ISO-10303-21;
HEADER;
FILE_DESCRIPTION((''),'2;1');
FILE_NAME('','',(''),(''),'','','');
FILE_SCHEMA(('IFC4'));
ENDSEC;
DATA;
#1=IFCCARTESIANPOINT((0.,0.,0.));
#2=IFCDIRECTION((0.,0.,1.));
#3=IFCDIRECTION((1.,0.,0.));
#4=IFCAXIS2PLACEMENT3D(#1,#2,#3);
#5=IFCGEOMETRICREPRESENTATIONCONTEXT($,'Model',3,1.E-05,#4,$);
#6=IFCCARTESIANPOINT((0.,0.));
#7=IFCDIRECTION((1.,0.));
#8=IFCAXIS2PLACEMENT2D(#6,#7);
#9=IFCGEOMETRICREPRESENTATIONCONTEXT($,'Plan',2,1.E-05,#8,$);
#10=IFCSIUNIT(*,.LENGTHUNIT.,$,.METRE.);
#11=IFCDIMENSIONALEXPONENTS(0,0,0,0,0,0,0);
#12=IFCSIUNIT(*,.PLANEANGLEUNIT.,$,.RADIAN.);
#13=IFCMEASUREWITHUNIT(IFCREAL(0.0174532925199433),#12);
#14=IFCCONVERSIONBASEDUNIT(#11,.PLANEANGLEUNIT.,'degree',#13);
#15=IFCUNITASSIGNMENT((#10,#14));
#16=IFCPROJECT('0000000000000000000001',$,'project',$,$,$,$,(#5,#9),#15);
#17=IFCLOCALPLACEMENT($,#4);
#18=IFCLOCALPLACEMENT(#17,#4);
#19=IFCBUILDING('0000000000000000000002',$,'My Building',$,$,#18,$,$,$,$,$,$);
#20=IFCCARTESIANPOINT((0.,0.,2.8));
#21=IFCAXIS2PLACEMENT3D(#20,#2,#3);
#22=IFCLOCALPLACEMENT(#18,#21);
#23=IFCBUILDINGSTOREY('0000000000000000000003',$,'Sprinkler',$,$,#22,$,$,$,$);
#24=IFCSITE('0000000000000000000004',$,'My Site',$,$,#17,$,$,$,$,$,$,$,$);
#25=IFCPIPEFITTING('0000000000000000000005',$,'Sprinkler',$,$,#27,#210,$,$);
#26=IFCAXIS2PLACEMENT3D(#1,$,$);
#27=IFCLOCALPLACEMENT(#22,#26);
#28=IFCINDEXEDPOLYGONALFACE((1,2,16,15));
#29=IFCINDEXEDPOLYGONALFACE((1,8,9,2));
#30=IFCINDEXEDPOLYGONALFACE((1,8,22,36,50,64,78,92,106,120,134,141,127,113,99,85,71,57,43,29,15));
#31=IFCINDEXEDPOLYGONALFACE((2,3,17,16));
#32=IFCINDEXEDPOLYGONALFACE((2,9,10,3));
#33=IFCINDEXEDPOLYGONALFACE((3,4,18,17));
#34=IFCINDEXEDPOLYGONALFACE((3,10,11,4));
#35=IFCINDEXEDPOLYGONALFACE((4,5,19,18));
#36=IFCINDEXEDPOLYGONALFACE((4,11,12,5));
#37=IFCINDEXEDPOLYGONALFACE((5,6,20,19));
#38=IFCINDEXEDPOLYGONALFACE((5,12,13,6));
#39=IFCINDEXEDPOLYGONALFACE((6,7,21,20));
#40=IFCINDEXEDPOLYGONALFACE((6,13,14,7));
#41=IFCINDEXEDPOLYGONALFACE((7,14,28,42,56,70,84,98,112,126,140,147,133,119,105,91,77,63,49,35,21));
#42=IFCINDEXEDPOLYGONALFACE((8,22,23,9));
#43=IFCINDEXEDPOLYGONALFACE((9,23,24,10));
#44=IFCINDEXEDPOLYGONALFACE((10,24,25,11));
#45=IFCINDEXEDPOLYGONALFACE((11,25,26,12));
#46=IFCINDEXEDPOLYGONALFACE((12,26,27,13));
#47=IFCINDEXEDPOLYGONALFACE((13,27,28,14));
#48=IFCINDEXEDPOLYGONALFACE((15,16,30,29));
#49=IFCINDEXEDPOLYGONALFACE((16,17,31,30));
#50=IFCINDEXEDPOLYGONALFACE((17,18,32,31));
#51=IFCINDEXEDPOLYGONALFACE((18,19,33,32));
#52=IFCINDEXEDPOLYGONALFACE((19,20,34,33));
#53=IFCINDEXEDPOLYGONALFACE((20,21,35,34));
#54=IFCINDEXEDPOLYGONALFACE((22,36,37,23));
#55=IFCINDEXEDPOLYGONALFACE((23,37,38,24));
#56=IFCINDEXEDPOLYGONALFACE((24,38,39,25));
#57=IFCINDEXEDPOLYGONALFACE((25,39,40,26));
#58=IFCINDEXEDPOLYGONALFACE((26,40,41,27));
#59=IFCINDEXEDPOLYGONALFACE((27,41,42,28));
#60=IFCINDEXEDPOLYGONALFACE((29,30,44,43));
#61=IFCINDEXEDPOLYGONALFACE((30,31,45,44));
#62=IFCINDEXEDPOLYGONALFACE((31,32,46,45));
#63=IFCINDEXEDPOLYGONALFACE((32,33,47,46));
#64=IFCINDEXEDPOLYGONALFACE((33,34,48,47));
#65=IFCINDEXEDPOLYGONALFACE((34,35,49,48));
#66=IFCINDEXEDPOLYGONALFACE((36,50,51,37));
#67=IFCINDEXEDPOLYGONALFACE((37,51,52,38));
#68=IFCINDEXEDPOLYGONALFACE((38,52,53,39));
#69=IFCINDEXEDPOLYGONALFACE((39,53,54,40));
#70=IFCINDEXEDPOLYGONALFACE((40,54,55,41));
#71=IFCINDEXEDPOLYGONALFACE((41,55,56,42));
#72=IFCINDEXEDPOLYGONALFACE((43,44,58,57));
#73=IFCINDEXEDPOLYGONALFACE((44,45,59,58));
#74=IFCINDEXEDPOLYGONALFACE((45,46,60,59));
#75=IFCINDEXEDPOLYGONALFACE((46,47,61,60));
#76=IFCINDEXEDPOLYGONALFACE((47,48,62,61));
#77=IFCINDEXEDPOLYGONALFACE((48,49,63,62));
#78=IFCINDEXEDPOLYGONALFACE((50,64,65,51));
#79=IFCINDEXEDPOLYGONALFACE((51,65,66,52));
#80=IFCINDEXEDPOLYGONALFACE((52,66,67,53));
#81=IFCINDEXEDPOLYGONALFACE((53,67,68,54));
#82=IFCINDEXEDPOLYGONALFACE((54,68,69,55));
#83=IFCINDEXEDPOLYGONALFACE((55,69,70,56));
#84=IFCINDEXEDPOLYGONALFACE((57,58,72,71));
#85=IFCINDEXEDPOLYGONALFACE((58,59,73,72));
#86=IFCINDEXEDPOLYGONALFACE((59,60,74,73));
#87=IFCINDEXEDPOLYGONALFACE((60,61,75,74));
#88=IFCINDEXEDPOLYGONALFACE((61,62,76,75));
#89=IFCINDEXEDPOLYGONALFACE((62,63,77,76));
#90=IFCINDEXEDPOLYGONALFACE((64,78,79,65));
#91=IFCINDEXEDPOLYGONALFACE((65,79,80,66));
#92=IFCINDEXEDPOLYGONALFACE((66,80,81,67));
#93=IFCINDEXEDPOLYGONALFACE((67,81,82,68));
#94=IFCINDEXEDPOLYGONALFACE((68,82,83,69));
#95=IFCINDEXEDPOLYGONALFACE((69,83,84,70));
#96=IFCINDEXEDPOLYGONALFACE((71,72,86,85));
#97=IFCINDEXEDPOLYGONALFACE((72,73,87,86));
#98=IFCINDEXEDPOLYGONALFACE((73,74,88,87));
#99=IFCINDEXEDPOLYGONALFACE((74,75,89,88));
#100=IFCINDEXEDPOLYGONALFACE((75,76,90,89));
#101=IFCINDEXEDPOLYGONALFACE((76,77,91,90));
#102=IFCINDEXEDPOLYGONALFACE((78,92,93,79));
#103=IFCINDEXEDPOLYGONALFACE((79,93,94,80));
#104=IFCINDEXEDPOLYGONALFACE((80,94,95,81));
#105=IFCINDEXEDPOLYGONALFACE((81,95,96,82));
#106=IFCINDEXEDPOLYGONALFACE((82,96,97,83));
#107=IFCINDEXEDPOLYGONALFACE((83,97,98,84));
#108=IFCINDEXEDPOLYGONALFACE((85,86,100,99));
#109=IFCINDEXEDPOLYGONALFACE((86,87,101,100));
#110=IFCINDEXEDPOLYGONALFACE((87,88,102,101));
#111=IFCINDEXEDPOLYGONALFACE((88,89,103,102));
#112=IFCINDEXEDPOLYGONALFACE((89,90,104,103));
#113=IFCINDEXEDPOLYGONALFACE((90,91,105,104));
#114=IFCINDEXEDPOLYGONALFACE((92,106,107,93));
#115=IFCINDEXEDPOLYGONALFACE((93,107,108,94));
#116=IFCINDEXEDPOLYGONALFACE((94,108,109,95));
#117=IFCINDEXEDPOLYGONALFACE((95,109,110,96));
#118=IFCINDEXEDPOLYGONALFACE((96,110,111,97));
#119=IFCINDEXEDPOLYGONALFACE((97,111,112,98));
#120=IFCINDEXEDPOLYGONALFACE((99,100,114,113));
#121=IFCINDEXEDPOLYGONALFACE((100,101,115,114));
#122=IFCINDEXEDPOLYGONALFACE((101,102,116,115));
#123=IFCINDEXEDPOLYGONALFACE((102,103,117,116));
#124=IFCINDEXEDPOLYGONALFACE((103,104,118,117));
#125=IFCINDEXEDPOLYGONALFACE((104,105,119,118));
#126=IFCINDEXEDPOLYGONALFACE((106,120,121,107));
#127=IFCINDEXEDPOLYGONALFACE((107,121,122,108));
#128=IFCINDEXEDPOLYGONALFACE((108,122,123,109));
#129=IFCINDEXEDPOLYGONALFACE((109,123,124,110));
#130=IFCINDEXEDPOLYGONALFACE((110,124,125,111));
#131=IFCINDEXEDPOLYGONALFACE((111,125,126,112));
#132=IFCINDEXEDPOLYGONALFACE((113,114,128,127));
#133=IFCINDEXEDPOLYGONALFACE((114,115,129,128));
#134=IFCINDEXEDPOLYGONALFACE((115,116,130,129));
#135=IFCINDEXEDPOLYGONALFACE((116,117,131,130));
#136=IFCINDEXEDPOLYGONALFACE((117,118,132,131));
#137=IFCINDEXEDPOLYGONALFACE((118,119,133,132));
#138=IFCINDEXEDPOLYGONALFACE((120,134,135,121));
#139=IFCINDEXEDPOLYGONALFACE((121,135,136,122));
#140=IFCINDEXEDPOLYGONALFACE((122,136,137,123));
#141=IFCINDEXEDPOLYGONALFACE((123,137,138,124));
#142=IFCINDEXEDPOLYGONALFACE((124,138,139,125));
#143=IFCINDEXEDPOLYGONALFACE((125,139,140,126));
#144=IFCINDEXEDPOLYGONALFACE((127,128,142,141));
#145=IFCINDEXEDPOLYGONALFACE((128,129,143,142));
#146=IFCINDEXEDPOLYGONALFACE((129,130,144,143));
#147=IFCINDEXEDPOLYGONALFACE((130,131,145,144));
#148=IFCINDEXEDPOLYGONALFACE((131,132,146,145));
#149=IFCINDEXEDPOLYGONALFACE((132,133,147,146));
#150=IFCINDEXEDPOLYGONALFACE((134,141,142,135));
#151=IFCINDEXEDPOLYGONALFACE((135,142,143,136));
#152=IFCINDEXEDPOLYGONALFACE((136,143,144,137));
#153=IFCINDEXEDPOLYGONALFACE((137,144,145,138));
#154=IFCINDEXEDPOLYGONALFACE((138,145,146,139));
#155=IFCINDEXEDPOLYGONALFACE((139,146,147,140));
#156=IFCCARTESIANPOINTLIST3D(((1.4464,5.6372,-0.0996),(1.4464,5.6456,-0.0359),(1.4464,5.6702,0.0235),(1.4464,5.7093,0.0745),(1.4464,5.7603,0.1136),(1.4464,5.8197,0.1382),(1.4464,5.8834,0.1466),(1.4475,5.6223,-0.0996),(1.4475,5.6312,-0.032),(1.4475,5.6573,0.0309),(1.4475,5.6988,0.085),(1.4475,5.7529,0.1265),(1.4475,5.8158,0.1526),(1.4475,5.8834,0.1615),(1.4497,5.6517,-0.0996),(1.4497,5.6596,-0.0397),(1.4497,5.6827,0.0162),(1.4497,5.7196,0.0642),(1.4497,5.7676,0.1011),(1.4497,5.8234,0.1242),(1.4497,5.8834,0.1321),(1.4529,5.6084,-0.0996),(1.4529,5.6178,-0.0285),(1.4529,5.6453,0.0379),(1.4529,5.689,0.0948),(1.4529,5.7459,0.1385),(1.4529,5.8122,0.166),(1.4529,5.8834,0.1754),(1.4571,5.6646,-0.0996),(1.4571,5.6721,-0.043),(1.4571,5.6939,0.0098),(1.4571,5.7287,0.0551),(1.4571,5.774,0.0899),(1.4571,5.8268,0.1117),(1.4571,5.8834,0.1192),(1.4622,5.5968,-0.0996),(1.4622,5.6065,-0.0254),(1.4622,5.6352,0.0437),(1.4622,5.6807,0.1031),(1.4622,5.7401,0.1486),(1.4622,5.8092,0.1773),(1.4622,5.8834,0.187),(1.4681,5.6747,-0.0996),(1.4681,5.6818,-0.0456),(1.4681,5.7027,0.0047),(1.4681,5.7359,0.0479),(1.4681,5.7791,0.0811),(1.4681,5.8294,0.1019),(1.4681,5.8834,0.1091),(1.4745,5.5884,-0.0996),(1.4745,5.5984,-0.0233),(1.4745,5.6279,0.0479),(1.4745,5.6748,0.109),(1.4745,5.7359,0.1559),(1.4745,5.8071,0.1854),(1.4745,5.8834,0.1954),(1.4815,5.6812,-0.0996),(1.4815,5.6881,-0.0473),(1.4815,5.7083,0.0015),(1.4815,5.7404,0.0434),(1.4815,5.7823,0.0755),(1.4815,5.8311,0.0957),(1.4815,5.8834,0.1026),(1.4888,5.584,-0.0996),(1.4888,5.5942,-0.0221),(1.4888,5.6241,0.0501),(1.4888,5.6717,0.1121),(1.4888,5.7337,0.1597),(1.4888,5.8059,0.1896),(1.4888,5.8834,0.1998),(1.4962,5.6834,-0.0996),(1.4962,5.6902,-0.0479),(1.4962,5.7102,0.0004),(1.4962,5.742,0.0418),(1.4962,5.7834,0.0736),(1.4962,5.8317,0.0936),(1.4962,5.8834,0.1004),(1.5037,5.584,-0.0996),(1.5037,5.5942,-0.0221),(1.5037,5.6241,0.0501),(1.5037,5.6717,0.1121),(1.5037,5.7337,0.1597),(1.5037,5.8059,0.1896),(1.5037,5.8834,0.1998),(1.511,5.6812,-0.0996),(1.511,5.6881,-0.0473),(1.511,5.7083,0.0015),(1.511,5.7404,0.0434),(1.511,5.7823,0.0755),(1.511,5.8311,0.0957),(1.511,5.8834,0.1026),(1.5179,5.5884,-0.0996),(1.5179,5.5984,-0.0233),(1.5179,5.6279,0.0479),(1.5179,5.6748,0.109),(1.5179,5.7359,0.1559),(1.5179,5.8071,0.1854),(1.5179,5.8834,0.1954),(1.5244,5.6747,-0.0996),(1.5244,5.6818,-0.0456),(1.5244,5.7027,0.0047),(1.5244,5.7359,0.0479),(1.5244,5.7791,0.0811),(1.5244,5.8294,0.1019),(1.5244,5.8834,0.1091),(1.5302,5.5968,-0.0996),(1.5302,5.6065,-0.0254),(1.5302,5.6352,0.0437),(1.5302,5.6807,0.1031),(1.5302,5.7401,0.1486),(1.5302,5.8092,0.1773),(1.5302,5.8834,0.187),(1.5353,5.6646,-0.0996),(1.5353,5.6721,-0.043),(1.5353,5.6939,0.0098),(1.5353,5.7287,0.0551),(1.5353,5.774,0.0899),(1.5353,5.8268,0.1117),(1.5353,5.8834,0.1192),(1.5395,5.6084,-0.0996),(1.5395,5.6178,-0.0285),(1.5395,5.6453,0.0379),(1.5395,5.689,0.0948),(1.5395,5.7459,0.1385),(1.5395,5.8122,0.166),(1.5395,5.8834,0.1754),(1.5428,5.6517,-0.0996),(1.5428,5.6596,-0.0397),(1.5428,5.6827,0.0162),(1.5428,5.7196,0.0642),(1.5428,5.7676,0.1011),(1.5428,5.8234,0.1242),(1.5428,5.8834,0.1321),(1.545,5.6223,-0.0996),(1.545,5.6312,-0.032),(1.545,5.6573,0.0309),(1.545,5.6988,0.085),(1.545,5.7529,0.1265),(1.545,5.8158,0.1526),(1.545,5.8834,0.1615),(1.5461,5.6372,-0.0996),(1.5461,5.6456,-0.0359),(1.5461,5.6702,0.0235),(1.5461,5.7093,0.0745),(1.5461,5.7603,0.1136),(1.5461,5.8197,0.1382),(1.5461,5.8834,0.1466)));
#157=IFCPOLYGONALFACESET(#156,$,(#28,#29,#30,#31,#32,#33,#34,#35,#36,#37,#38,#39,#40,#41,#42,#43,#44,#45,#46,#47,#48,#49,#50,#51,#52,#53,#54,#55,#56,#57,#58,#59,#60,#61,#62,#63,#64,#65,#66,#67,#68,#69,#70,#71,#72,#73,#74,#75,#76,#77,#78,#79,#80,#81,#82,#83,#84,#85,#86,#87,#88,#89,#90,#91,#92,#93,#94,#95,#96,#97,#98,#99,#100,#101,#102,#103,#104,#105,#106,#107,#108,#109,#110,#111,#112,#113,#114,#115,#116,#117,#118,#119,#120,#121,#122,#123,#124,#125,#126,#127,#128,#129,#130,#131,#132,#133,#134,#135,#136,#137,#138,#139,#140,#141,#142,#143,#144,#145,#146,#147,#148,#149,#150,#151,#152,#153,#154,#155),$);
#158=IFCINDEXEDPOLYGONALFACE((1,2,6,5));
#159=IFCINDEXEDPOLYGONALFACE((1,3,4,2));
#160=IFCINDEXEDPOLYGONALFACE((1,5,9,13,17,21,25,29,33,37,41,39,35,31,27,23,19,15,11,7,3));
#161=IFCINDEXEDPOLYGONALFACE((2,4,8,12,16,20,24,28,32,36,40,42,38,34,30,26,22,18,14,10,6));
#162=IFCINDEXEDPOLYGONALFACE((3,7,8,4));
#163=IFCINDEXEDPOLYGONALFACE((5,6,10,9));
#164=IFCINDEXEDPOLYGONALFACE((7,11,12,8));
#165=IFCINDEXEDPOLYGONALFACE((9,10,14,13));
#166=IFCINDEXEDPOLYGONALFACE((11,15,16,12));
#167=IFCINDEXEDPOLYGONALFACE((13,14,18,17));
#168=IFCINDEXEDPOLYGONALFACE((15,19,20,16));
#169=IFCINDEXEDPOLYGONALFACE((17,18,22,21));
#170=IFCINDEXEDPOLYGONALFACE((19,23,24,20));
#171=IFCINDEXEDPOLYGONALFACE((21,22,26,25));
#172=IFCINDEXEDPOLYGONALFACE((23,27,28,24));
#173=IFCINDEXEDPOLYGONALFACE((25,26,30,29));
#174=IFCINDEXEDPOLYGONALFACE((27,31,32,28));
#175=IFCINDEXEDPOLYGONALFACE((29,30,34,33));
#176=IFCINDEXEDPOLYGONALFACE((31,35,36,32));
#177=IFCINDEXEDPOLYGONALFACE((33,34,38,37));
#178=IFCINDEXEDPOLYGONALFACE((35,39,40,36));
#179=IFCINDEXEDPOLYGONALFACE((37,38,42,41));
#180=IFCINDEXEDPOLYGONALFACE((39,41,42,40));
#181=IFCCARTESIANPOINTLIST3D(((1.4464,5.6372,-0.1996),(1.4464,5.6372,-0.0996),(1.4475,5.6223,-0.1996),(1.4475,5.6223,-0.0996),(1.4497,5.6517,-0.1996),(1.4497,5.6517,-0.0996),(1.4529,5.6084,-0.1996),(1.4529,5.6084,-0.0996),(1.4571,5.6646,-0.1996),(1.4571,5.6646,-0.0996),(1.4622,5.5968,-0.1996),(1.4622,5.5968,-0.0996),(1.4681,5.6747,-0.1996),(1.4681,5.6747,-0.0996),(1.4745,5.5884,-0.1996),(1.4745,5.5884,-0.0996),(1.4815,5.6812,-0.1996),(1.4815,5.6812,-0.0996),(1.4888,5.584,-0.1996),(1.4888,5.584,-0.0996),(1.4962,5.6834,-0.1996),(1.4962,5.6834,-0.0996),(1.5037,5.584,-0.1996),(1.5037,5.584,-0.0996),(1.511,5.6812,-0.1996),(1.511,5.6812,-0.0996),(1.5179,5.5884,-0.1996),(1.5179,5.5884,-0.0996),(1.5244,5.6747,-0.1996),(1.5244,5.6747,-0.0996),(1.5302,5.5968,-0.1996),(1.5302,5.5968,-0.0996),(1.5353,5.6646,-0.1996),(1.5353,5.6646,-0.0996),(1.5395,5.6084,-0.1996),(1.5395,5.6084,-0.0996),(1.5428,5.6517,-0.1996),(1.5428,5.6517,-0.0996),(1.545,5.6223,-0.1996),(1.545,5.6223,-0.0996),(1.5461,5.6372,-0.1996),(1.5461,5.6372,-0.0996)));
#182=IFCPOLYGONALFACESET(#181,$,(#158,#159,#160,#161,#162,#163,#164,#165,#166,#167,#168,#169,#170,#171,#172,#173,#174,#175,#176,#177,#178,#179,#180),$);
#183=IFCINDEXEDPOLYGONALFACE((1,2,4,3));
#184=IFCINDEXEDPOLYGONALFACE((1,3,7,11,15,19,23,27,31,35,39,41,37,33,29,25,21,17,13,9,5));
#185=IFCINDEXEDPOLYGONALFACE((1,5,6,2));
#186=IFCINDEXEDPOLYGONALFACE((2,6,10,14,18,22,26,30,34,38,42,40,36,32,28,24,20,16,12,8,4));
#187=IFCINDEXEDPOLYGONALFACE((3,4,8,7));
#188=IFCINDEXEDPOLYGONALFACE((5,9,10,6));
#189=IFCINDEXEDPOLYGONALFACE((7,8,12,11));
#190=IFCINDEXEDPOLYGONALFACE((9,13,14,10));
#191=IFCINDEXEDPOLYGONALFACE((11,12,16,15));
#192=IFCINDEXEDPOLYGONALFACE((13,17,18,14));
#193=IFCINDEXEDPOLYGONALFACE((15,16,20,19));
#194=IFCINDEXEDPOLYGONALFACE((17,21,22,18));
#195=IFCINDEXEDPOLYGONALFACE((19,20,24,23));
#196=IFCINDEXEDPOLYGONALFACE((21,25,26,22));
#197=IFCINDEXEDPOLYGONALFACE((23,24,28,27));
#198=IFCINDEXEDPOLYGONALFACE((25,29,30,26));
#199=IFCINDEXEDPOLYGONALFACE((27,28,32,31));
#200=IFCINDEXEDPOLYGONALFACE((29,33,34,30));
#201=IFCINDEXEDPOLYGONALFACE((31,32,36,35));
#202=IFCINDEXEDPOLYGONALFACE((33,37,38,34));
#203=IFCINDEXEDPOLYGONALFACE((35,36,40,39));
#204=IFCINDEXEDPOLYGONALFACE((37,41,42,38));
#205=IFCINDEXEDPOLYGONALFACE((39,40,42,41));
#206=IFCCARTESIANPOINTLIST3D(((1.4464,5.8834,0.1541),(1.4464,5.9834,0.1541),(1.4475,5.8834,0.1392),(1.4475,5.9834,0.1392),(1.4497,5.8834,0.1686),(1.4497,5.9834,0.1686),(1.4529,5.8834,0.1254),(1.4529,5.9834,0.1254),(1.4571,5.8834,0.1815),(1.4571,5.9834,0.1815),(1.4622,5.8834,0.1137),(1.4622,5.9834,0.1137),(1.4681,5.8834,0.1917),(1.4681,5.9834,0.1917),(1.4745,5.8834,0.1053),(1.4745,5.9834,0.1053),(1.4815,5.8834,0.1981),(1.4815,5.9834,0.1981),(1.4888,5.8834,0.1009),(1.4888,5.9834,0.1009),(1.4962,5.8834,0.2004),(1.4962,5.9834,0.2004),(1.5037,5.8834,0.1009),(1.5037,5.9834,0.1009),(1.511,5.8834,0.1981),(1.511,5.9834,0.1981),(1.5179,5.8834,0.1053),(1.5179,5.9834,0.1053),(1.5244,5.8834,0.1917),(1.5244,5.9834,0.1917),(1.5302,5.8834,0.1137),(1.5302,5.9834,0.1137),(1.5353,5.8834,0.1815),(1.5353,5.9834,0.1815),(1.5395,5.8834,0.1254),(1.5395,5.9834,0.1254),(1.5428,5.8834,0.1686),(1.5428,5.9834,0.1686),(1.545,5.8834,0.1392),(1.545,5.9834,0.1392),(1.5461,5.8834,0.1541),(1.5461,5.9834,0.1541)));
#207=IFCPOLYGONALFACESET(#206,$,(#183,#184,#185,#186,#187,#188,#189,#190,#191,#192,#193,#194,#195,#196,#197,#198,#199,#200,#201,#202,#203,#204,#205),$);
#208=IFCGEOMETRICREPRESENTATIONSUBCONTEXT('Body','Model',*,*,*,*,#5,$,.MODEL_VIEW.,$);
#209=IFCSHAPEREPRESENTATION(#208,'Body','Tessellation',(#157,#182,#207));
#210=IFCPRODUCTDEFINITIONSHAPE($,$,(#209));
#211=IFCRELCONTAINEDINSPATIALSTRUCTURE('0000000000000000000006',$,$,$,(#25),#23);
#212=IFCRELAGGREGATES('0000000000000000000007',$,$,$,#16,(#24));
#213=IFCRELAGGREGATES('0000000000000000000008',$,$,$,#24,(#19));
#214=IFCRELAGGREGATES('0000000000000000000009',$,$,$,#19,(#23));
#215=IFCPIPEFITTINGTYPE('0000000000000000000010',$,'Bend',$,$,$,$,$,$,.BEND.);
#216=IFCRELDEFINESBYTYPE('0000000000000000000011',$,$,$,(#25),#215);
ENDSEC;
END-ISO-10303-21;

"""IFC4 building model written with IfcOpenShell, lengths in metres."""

from ifc_helpers import new_model, entity, si_unit, converted_unit, frame, origin_with_axes, origin_2d_with_axis, place, context, subcontext, project, spatial, circle, extrude, source, transform, mapped, type_object, type_shapes, element, save


model = new_model("IFC4")

# Units and contexts
model_context = context("Model", 3, precision=1e-05, world=origin_with_axes())
plan_context = context("Plan", 2, precision=1e-05, world=origin_2d_with_axis())
body_context = subcontext(model_context, "Body", "Model", "MODEL_VIEW")
ifc_project = project(units=[si_unit("LENGTHUNIT", "METRE"), converted_unit("PLANEANGLEUNIT", "degree", entity("IfcReal", 0.0174532925199433), si_unit("PLANEANGLEUNIT", "RADIAN"), dimensions=[0, 0, 0, 0, 0, 0, 0])], contexts=[model_context, plan_context])

# Site, building, storey
site_placement = place(None, origin_with_axes())
site = spatial("IfcSite", under=ifc_project, at=site_placement, Name="My Site")
building_placement = place(site_placement, origin_with_axes())
building = spatial("IfcBuilding", under=site, at=building_placement, Name="My Building")
storey_placement = place(building_placement, frame((0.0, 0.0, 2.8), z_axis=(0.0, 0.0, 1.0), x_axis=(1.0, 0.0, 0.0)))
storey = spatial("IfcBuildingStorey", under=building, at=storey_placement, Name="Sprinkler")

# Pipe fitting
pipe_fitting_type_1 = type_object("IfcPipeFittingType", Name="Bend", PredefinedType="BEND")
shared_shape = source(origin_with_axes(), body_context, "Body", "SolidModel", [
    entity("IfcSweptDiskSolid", entity("IfcIndexedPolyCurve", entity("IfcCartesianPointList3D", [[0.0, 0.0, 0.1], [0.0732, 0.0, 0.2768], [0.25, 0.0, 0.35]]), [entity("IfcArcIndex", [1, 2, 3])]), 0.05),
    extrude(circle(Radius=0.05), origin_with_axes(), (0.0, 0.0, 1.0), 0.1),
    extrude(circle(Radius=0.05), frame((0.25, 0.0, 0.35), z_axis=(1.0, 0.0, 0.000001), x_axis=(-0.000001, 0.0, 1.0)), (0.0, 0.0, 1.0), 0.1),
])
type_shapes(pipe_fitting_type_1, [shared_shape])
for number, where, z_axis, x_axis, name in (
    (1, (1.4962, 5.6334, -0.1996), (0.0, 0.000008, 1.0), (0.0, 1.0, -0.000008), "Sprinkler"),
):
    element("IfcPipeFitting", number, at=place(storey_placement, frame(where, z_axis=z_axis, x_axis=x_axis)), inside=storey, type_object=pipe_fitting_type_1, Name=name, context=body_context, shape_type="MappedRepresentation", body=[
        mapped(shared_shape, transform((0.0, 0.0, 0.0), x_axis=(1.0, 0.0, 0.0), y_axis=(0.0, 1.0, 0.0), z_axis=(0.0, 0.0, 1.0), scale=1.0)),
    ])

save(model, "model.ifc")
